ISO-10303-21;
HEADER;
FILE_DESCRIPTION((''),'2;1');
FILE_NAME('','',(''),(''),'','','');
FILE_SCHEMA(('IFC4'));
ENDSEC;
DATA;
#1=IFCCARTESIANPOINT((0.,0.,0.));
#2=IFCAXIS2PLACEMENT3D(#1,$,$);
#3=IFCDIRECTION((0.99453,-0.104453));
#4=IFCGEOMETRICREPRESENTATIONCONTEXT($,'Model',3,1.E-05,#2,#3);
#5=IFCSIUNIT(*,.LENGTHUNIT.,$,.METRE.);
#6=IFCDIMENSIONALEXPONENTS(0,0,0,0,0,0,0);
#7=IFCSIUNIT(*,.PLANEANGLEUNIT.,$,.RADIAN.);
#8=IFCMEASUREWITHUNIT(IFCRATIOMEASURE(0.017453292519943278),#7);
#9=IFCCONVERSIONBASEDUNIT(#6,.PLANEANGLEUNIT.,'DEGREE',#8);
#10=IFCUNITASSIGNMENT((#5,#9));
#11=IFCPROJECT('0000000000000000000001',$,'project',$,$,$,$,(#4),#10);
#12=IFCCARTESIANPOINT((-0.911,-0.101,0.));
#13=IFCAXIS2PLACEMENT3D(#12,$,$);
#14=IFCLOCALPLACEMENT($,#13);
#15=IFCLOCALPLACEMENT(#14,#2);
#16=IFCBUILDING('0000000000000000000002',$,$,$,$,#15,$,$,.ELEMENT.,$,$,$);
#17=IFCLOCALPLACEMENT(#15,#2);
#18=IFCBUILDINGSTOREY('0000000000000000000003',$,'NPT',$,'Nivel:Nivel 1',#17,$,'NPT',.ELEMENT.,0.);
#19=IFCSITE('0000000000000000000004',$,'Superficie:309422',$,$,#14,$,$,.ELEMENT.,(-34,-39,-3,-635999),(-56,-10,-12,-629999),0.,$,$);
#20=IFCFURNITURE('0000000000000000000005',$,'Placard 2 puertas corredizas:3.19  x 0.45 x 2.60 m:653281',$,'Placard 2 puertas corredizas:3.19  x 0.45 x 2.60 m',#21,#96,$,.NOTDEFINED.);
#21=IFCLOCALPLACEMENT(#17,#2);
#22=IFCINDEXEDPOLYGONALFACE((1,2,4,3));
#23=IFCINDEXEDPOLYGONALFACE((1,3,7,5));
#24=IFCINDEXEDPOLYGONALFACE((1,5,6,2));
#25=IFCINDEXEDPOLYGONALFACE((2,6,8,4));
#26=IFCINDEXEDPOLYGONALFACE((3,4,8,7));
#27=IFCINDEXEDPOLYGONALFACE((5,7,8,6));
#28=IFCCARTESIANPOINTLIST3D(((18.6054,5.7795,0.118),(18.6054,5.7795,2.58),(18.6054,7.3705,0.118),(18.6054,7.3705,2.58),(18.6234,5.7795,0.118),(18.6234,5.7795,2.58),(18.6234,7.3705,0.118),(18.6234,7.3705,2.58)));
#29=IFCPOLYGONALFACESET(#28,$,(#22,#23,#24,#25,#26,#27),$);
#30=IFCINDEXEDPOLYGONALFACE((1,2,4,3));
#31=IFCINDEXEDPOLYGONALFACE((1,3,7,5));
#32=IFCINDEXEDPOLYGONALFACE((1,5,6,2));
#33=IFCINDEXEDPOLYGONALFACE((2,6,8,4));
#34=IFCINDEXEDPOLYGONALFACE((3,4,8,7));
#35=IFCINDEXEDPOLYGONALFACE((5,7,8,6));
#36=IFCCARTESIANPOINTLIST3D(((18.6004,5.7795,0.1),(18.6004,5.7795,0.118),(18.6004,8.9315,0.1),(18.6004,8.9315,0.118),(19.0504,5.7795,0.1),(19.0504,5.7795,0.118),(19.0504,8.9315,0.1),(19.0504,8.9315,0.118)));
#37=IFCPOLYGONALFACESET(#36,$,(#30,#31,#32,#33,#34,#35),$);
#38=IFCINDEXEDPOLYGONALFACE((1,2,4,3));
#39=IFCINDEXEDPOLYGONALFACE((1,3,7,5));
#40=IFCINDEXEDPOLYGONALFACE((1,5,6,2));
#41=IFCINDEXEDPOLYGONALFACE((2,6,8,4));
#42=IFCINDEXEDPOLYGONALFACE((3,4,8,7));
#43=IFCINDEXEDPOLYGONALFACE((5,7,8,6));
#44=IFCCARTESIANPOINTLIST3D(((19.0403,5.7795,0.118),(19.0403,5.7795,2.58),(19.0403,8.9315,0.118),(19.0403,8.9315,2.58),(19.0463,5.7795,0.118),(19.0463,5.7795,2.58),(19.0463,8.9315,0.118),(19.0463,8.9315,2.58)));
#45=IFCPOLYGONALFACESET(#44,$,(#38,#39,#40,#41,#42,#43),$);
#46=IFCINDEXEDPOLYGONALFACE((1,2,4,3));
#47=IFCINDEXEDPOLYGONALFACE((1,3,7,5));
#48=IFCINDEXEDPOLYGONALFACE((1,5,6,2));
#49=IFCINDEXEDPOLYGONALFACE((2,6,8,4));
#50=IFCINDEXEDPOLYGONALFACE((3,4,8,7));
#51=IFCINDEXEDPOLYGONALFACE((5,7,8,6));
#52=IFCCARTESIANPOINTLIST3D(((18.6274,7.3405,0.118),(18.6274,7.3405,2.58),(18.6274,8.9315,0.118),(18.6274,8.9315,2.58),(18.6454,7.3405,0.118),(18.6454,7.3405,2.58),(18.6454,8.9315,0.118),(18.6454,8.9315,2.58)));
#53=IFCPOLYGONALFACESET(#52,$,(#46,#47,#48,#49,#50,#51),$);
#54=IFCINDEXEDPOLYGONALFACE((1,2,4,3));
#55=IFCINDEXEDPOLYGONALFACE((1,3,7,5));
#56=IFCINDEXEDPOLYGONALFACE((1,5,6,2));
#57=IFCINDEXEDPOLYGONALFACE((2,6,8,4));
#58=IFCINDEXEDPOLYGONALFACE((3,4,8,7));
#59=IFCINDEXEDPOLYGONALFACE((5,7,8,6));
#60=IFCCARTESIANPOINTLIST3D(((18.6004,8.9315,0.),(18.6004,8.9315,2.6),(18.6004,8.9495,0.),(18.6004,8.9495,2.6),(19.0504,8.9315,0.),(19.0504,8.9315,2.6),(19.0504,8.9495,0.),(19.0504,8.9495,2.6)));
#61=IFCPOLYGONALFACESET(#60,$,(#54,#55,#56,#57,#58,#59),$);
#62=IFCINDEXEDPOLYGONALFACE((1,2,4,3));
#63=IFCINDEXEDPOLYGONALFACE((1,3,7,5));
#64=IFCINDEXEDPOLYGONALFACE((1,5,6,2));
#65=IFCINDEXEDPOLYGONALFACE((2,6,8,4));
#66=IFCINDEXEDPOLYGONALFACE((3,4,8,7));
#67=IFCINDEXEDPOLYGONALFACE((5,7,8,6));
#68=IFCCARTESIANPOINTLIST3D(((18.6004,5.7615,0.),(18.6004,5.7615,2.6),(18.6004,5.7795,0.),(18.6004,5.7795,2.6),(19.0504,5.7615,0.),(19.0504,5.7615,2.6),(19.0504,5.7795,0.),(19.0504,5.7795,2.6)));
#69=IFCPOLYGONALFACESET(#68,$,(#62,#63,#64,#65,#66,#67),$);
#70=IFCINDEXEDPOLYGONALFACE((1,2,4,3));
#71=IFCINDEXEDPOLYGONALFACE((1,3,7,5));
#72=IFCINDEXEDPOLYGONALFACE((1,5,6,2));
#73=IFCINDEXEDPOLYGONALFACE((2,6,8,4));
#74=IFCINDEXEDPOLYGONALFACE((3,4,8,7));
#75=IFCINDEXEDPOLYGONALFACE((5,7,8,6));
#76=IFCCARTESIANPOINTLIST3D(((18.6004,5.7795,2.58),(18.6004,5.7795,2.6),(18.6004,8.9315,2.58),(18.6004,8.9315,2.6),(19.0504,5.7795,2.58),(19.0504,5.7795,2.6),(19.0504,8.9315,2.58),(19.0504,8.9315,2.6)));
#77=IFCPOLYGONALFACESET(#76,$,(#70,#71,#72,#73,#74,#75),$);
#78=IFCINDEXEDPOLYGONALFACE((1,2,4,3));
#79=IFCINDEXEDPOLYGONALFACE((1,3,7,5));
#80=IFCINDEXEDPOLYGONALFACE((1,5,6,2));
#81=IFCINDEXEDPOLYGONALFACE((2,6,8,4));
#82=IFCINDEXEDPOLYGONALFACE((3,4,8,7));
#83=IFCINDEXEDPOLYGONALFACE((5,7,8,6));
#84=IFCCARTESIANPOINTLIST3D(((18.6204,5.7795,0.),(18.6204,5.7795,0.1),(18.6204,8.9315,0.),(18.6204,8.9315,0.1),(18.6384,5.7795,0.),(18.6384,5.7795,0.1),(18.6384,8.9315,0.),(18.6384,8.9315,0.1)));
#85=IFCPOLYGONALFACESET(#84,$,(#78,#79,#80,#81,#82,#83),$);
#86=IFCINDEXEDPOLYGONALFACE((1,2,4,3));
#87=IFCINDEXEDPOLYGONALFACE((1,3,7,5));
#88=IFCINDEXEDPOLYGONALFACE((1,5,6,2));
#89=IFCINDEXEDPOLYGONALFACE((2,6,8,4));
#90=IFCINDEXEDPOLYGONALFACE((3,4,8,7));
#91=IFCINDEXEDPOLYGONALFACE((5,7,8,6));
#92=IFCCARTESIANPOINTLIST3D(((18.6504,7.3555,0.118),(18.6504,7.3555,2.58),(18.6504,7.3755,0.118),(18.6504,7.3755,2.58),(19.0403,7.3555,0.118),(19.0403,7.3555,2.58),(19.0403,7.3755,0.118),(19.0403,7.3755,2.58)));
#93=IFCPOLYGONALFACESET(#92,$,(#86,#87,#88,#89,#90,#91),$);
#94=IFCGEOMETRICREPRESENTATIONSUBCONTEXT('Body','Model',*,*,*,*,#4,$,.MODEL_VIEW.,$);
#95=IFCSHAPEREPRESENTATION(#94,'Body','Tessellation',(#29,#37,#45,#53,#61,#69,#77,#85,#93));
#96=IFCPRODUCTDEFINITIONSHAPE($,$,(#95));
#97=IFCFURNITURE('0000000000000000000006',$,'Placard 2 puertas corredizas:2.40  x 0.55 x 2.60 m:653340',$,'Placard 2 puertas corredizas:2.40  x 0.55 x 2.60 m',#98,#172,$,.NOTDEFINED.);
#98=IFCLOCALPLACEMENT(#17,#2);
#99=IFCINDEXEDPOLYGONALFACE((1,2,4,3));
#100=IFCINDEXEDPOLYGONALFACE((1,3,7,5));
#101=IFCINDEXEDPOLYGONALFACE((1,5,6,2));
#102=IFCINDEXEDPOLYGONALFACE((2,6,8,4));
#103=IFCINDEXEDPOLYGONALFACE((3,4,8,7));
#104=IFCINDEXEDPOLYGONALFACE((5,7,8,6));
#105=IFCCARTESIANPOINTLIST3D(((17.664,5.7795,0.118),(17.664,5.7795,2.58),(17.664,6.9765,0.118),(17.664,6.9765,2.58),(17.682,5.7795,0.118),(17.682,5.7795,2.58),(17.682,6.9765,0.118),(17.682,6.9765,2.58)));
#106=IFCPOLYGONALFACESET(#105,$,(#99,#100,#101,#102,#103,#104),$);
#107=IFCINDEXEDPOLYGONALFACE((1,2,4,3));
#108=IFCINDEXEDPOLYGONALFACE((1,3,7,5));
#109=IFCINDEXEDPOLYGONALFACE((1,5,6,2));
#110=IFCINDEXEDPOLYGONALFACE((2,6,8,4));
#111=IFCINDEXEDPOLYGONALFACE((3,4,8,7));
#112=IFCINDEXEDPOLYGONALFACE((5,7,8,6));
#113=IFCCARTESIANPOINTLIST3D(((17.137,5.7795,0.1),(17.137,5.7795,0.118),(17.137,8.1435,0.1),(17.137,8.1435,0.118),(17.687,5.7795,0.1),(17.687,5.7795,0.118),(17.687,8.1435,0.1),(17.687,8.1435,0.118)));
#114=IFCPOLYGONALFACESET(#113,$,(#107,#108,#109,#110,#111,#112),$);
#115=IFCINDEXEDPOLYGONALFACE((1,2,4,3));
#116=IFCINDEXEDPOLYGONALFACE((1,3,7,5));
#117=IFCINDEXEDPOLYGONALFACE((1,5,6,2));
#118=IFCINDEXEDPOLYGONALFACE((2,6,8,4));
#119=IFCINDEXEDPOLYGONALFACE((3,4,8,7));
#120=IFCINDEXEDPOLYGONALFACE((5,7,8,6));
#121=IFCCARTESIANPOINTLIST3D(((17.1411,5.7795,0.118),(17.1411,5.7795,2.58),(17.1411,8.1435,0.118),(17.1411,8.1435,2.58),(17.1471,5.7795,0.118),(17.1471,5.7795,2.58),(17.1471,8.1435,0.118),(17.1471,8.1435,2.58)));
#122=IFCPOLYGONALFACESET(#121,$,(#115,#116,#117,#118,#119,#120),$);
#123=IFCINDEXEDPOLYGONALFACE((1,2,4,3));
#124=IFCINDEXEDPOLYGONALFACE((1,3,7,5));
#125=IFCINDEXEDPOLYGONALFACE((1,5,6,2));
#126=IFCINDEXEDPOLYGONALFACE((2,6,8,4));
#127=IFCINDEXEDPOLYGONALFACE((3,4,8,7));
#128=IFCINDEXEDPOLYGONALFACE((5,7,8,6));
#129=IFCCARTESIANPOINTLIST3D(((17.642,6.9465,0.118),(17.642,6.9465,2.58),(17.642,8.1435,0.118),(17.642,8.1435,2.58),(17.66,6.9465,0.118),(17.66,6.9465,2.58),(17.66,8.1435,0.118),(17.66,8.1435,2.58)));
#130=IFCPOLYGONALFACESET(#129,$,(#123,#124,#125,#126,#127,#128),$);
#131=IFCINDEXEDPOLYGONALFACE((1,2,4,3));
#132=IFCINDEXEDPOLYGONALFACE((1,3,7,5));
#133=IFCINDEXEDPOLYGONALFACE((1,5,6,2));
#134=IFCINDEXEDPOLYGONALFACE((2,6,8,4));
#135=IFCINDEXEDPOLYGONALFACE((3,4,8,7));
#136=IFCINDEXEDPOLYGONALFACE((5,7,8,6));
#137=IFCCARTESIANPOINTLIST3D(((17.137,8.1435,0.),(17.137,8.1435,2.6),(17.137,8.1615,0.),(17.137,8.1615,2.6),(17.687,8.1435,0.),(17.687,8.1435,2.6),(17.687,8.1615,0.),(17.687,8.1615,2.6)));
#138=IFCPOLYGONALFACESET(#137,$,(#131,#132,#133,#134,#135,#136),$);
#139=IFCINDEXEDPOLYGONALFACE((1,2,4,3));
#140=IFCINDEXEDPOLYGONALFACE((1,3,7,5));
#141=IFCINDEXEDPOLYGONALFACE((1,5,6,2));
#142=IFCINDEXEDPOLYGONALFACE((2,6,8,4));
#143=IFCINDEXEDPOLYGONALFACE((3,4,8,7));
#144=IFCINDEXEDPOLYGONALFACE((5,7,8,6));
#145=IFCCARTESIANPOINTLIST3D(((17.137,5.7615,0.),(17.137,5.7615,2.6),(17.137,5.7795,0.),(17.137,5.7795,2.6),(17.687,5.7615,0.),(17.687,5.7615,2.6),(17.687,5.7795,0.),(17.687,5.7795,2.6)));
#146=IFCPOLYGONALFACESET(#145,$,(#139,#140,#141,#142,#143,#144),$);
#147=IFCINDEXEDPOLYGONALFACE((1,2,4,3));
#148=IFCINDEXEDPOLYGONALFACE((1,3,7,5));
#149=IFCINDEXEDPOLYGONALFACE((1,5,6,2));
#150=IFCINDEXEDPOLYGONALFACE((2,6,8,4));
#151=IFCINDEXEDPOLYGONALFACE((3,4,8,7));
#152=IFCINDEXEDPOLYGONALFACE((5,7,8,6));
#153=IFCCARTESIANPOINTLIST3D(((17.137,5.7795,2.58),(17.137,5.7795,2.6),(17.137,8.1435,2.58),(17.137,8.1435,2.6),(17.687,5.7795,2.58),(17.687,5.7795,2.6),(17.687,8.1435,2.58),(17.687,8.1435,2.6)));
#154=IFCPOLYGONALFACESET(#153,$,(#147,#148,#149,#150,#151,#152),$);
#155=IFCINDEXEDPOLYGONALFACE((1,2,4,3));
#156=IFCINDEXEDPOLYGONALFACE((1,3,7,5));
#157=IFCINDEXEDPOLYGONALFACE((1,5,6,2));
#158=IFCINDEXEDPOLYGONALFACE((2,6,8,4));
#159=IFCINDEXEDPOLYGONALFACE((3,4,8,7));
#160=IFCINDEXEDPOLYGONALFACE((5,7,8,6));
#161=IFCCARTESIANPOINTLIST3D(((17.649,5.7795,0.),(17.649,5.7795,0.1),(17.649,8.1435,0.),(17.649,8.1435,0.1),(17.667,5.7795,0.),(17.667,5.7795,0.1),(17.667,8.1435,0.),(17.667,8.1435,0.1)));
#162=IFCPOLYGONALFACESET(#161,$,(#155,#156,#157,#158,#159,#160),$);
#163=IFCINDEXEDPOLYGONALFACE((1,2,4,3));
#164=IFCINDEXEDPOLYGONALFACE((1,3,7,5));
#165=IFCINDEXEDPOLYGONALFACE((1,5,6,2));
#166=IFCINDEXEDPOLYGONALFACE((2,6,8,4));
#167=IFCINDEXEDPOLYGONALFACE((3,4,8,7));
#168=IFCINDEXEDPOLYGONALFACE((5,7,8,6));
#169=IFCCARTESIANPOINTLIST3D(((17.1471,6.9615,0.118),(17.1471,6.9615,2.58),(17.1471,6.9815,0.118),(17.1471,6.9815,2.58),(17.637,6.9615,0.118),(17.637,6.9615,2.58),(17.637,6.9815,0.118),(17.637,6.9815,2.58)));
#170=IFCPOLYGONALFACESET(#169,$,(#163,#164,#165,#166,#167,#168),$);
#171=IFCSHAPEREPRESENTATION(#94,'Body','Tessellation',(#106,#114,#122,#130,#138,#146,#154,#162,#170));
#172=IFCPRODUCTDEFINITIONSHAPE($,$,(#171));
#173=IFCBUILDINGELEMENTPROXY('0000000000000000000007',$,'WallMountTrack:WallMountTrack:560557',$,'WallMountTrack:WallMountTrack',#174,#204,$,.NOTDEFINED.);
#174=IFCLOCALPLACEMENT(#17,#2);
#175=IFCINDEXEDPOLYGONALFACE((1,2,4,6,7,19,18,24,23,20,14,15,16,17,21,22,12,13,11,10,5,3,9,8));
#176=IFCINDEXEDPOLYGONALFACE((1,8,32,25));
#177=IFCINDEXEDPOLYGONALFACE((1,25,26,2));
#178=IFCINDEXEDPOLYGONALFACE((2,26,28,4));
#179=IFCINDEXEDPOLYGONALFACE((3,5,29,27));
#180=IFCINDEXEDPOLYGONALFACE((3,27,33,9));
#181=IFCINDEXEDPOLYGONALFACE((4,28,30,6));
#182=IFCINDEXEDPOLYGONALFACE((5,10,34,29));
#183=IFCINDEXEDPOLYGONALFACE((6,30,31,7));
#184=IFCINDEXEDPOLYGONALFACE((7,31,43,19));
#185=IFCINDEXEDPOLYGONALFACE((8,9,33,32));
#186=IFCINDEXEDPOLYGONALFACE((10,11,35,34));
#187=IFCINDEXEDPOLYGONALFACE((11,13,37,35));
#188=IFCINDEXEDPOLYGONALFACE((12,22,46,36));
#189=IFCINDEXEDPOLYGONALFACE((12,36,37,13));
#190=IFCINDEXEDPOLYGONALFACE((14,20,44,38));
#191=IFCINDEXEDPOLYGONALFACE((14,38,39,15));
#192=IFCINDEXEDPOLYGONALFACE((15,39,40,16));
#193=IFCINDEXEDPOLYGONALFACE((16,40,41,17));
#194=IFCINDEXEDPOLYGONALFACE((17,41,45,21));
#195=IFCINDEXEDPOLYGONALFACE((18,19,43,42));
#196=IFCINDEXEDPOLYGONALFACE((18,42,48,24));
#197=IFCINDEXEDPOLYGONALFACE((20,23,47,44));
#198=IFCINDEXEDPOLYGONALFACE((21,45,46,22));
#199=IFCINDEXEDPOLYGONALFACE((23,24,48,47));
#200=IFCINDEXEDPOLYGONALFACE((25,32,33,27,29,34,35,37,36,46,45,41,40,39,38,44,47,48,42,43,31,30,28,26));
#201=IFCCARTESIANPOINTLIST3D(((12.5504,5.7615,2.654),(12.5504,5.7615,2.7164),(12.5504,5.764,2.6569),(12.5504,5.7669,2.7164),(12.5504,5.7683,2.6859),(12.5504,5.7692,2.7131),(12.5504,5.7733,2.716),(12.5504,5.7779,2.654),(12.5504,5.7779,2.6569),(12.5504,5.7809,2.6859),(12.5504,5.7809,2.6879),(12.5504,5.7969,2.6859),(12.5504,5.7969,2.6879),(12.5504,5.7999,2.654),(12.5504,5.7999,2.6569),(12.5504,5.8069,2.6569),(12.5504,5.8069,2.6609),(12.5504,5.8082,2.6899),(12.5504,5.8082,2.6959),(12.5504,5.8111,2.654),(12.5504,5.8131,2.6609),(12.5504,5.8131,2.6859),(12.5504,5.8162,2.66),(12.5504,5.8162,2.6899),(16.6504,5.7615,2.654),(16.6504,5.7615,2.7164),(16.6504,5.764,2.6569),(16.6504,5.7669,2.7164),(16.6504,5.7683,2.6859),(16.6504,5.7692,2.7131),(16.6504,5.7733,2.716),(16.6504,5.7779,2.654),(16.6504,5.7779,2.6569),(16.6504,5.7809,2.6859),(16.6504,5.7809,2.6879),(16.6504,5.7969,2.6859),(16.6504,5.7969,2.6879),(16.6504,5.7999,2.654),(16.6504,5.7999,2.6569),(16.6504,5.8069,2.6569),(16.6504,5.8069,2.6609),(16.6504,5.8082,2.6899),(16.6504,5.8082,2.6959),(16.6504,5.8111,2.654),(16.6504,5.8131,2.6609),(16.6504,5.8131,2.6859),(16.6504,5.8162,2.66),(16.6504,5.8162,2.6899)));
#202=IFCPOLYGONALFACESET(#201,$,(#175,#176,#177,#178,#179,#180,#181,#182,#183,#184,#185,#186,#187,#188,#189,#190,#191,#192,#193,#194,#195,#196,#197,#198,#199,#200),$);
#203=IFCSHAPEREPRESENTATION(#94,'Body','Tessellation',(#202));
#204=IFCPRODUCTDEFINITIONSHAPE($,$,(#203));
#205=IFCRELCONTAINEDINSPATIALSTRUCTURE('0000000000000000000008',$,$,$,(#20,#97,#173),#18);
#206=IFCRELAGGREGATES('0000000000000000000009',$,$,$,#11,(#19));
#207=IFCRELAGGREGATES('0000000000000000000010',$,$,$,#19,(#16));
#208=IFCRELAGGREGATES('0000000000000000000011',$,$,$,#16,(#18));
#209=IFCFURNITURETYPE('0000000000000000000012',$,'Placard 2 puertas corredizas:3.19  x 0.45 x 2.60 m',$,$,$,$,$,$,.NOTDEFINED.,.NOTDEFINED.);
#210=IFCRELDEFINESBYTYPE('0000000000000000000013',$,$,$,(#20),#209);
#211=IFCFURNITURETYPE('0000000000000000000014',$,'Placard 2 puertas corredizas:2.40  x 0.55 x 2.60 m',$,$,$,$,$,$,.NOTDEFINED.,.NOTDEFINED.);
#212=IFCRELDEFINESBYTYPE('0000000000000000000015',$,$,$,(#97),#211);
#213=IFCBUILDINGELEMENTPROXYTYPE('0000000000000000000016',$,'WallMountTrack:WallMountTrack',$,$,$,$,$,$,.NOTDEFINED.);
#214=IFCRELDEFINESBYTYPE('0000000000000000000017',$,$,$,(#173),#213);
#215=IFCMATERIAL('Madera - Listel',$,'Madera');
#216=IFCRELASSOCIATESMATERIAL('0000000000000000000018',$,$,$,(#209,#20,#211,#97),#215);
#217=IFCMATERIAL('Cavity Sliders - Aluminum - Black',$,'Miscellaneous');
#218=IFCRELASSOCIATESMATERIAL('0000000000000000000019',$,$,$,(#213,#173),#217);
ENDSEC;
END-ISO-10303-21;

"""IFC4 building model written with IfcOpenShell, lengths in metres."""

from ifc_helpers import new_model, entity, si_unit, converted_unit, direction, frame, frame_2d, origin, origin_2d_with_axis, place, context, subcontext, project, spatial, polyline, rectangle, outline, extrude, source, transform, mapped, material, type_object, type_shapes, element, save


model = new_model("IFC4")

# Units and contexts
model_context = context("Model", 3, precision=1e-05, world=origin(), true_north=direction((0.99453, -0.104453)))
body_context = subcontext(model_context, "Body", "Model", "MODEL_VIEW")
ifc_project = project(units=[si_unit("LENGTHUNIT", "METRE"), converted_unit("PLANEANGLEUNIT", "DEGREE", entity("IfcRatioMeasure", 0.017453292519943278), si_unit("PLANEANGLEUNIT", "RADIAN"), dimensions=[0, 0, 0, 0, 0, 0, 0])], contexts=[model_context])

# Site, building, storey
site_placement = place(None, frame((-0.911, -0.101, 0.0)))
site = spatial("IfcSite", under=ifc_project, at=site_placement, Name="Superficie:309422", CompositionType="ELEMENT", RefLatitude=(-34, -39, -3, -635999), RefLongitude=(-56, -10, -12, -629999), RefElevation=0.0)
building_placement = place(site_placement, origin())
building = spatial("IfcBuilding", under=site, at=building_placement, CompositionType="ELEMENT")
storey_placement = place(building_placement, origin())
storey = spatial("IfcBuildingStorey", under=building, at=storey_placement, Name="NPT", ObjectType="Nivel:Nivel 1", LongName="NPT", CompositionType="ELEMENT", Elevation=0.0)

# Furniture
ifc_material_1 = material(Name="Madera - Listel", Category="Madera")
furniture_type_1 = type_object("IfcFurnitureType", Name="Placard 2 puertas corredizas:3.19  x 0.45 x 2.60 m", AssemblyPlace="NOTDEFINED", PredefinedType="NOTDEFINED", material=ifc_material_1)
shared_shape_1 = source(origin(), body_context, "Body", "SweptSolid", [
    extrude(rectangle(XDim=1.591, YDim=0.018, at=frame_2d((0.0, 0.0), x_axis=(1.0, 0.0))), frame((-0.7805, 0.161, 0.118), z_axis=(0.0, 0.0, 1.0), x_axis=(-1.0, 0.0, 0.0)), (0.0, 0.0, 1.0), 2.462),
    extrude(rectangle(XDim=3.152, YDim=0.45, at=origin_2d_with_axis()), frame((0.0, -0.05, 0.1), z_axis=(0.0, 0.0, 1.0), x_axis=(-1.0, 0.0, 0.0)), (0.0, 0.0, 1.0), 0.018),
    extrude(rectangle(XDim=0.006, YDim=3.152, at=frame_2d((0.0, 0.0), x_axis=(1.0, 0.0))), frame((0.0, -0.2679, 0.118), z_axis=(0.0, 0.0, 1.0), x_axis=(0.0, 1.0, 0.0)), (0.0, 0.0, 1.0), 2.462),
    extrude(rectangle(XDim=1.591, YDim=0.018, at=origin_2d_with_axis()), frame((0.7805, 0.139, 0.118), z_axis=(0.0, 0.0, 1.0), x_axis=(-1.0, 0.0, 0.0)), (0.0, 0.0, 1.0), 2.462),
    extrude(rectangle(XDim=0.018, YDim=0.45, at=frame_2d((0.0, 0.0), x_axis=(1.0, 0.0))), frame((1.585, -0.05, 0.0)), (0.0, 0.0, 1.0), 2.6),
    extrude(rectangle(XDim=0.45, YDim=0.018, at=frame_2d((0.0, 0.0), x_axis=(1.0, 0.0))), frame((-1.585, -0.05, 0.0), z_axis=(0.0, 0.0, 1.0), x_axis=(0.0, 1.0, 0.0)), (0.0, 0.0, 1.0), 2.6),
    extrude(rectangle(XDim=3.152, YDim=0.45, at=origin_2d_with_axis()), frame((0.0, -0.05, 2.58), z_axis=(0.0, 0.0, 1.0), x_axis=(-1.0, 0.0, 0.0)), (0.0, 0.0, 1.0), 0.02),
    extrude(rectangle(XDim=3.152, YDim=0.018, at=frame_2d((0.0, 0.0), x_axis=(1.0, 0.0))), frame((0.0, 0.146, 0.0), z_axis=(0.0, 0.0, 1.0), x_axis=(-1.0, 0.0, 0.0)), (0.0, 0.0, 1.0), 0.1),
    extrude(rectangle(XDim=0.3899, YDim=0.02, at=frame_2d((0.0, 0.0), x_axis=(1.0, 0.0))), frame((0.01, -0.0699, 0.118), z_axis=(0.0, 0.0, 1.0), x_axis=(0.0, 1.0, 0.0)), (0.0, 0.0, 1.0), 2.462),
])
type_shapes(furniture_type_1, [shared_shape_1])
furniture_1_placement = place(storey_placement, frame((18.7754, 7.3555, 0.0), z_axis=(0.0, 0.0, 1.0), x_axis=(0.0, 1.0, 0.0)))
element("IfcFurniture", 1, at=furniture_1_placement, inside=storey, type_object=furniture_type_1, material=ifc_material_1, Name="Placard 2 puertas corredizas:3.19  x 0.45 x 2.60 m:653281", ObjectType="Placard 2 puertas corredizas:3.19  x 0.45 x 2.60 m", PredefinedType="NOTDEFINED", context=body_context, shape_type="MappedRepresentation", body=[
    mapped(shared_shape_1, transform((0.0, 0.0, 0.0), scale=1.0)),
])
furniture_type_2 = type_object("IfcFurnitureType", Name="Placard 2 puertas corredizas:2.40  x 0.55 x 2.60 m", AssemblyPlace="NOTDEFINED", PredefinedType="NOTDEFINED", material=ifc_material_1)
shared_shape_2 = source(origin(), body_context, "Body", "SweptSolid", [
    extrude(rectangle(XDim=0.018, YDim=1.197, at=frame_2d((0.0, 0.0), x_axis=(1.0, 0.0))), frame((-0.5835, -0.261, 0.118), z_axis=(0.0, 0.0, 1.0), x_axis=(0.0, 1.0, 0.0)), (0.0, 0.0, 1.0), 2.462),
    extrude(rectangle(XDim=0.55, YDim=2.364, at=origin_2d_with_axis()), frame((0.0, 0.0, 0.1), z_axis=(0.0, 0.0, 1.0), x_axis=(0.0, 1.0, 0.0)), (0.0, 0.0, 1.0), 0.018),
    extrude(rectangle(XDim=2.364, YDim=0.006, at=origin_2d_with_axis()), frame((0.0, 0.2679, 0.118), z_axis=(0.0, 0.0, 1.0), x_axis=(-1.0, 0.0, 0.0)), (0.0, 0.0, 1.0), 2.462),
    extrude(rectangle(XDim=0.018, YDim=1.197, at=frame_2d((0.0, 0.0), x_axis=(1.0, 0.0))), frame((0.5835, -0.239, 0.118), z_axis=(0.0, 0.0, 1.0), x_axis=(0.0, 1.0, 0.0)), (0.0, 0.0, 1.0), 2.462),
    extrude(rectangle(XDim=0.55, YDim=0.018, at=frame_2d((0.0, 0.0), x_axis=(1.0, 0.0))), frame((1.191, 0.0, 0.0), z_axis=(0.0, 0.0, 1.0), x_axis=(0.0, -1.0, 0.0)), (0.0, 0.0, 1.0), 2.6),
    extrude(rectangle(XDim=0.018, YDim=0.55, at=frame_2d((0.0, 0.0), x_axis=(1.0, 0.0))), frame((-1.191, 0.0, 0.0), z_axis=(0.0, 0.0, 1.0), x_axis=(-1.0, 0.0, 0.0)), (0.0, 0.0, 1.0), 2.6),
    extrude(rectangle(XDim=0.55, YDim=2.364, at=origin_2d_with_axis()), frame((0.0, 0.0, 2.58), z_axis=(0.0, 0.0, 1.0), x_axis=(0.0, 1.0, 0.0)), (0.0, 0.0, 1.0), 0.02),
    extrude(rectangle(XDim=0.018, YDim=2.364, at=origin_2d_with_axis()), frame((0.0, -0.246, 0.0), z_axis=(0.0, 0.0, 1.0), x_axis=(0.0, 1.0, 0.0)), (0.0, 0.0, 1.0), 0.1),
    extrude(rectangle(XDim=0.02, YDim=0.4899, at=frame_2d((0.0, 0.0), x_axis=(1.0, 0.0))), frame((0.01, 0.0199, 0.118), z_axis=(0.0, 0.0, 1.0), x_axis=(-1.0, 0.0, 0.0)), (0.0, 0.0, 1.0), 2.462),
])
type_shapes(furniture_type_2, [shared_shape_2])
furniture_2_placement = place(storey_placement, frame((17.412, 6.9615, 0.0), z_axis=(0.0, 0.0, 1.0), x_axis=(0.0, 1.0, 0.0)))
element("IfcFurniture", 2, at=furniture_2_placement, inside=storey, type_object=furniture_type_2, material=ifc_material_1, Name="Placard 2 puertas corredizas:2.40  x 0.55 x 2.60 m:653340", ObjectType="Placard 2 puertas corredizas:2.40  x 0.55 x 2.60 m", PredefinedType="NOTDEFINED", context=body_context, shape_type="MappedRepresentation", body=[
    mapped(shared_shape_2, transform((0.0, 0.0, 0.0), scale=1.0)),
])

# Building element proxy
ifc_material_2 = material(Name="Cavity Sliders - Aluminum - Black", Category="Miscellaneous")
building_element_proxy_type = type_object("IfcBuildingElementProxyType", Name="WallMountTrack:WallMountTrack", PredefinedType="NOTDEFINED", material=ifc_material_2)
shared_shape_3 = source(origin(), body_context, "Body", "SweptSolid", [
    extrude(outline(polyline([(-0.0115, -0.0255), (0.0184, -0.0255), (0.0244, -0.0205), (0.0244, -0.0093), (0.0215, -0.0093), (0.0215, -0.0162), (0.0175, -0.0162), (0.0175, -0.0224), (-0.0075, -0.0224), (-0.0075, -0.0063), (-0.0095, -0.0063), (-0.0095, 0.0097), (-0.0075, 0.0097), (-0.0075, 0.0223), (0.0215, 0.0267), (0.0215, 0.0127), (0.0244, 0.0127), (0.0244, 0.0291), (-0.038, 0.0291), (-0.038, 0.0237), (-0.0347, 0.0215), (-0.0376, 0.0174), (-0.0175, -0.0175), (-0.0115, -0.0175), (-0.0115, -0.0255)])), frame((-2.05, -0.0291, 0.0244), z_axis=(1.0, 0.0, 0.0), x_axis=(0.0, 0.0, -1.0)), (0.0, 0.0, 1.0), 4.1),
])
type_shapes(building_element_proxy_type, [shared_shape_3])
proxy_placement = place(storey_placement, frame((14.6004, 5.7615, 2.654), z_axis=(0.0, 0.0, 1.0), x_axis=(-1.0, 0.0, 0.0)))
element("IfcBuildingElementProxy", 3, at=proxy_placement, inside=storey, type_object=building_element_proxy_type, material=ifc_material_2, Name="WallMountTrack:WallMountTrack:560557", ObjectType="WallMountTrack:WallMountTrack", PredefinedType="NOTDEFINED", context=body_context, shape_type="MappedRepresentation", body=[
    mapped(shared_shape_3, transform((0.0, 0.0, 0.0), scale=1.0)),
])

save(model, "model.ifc")
